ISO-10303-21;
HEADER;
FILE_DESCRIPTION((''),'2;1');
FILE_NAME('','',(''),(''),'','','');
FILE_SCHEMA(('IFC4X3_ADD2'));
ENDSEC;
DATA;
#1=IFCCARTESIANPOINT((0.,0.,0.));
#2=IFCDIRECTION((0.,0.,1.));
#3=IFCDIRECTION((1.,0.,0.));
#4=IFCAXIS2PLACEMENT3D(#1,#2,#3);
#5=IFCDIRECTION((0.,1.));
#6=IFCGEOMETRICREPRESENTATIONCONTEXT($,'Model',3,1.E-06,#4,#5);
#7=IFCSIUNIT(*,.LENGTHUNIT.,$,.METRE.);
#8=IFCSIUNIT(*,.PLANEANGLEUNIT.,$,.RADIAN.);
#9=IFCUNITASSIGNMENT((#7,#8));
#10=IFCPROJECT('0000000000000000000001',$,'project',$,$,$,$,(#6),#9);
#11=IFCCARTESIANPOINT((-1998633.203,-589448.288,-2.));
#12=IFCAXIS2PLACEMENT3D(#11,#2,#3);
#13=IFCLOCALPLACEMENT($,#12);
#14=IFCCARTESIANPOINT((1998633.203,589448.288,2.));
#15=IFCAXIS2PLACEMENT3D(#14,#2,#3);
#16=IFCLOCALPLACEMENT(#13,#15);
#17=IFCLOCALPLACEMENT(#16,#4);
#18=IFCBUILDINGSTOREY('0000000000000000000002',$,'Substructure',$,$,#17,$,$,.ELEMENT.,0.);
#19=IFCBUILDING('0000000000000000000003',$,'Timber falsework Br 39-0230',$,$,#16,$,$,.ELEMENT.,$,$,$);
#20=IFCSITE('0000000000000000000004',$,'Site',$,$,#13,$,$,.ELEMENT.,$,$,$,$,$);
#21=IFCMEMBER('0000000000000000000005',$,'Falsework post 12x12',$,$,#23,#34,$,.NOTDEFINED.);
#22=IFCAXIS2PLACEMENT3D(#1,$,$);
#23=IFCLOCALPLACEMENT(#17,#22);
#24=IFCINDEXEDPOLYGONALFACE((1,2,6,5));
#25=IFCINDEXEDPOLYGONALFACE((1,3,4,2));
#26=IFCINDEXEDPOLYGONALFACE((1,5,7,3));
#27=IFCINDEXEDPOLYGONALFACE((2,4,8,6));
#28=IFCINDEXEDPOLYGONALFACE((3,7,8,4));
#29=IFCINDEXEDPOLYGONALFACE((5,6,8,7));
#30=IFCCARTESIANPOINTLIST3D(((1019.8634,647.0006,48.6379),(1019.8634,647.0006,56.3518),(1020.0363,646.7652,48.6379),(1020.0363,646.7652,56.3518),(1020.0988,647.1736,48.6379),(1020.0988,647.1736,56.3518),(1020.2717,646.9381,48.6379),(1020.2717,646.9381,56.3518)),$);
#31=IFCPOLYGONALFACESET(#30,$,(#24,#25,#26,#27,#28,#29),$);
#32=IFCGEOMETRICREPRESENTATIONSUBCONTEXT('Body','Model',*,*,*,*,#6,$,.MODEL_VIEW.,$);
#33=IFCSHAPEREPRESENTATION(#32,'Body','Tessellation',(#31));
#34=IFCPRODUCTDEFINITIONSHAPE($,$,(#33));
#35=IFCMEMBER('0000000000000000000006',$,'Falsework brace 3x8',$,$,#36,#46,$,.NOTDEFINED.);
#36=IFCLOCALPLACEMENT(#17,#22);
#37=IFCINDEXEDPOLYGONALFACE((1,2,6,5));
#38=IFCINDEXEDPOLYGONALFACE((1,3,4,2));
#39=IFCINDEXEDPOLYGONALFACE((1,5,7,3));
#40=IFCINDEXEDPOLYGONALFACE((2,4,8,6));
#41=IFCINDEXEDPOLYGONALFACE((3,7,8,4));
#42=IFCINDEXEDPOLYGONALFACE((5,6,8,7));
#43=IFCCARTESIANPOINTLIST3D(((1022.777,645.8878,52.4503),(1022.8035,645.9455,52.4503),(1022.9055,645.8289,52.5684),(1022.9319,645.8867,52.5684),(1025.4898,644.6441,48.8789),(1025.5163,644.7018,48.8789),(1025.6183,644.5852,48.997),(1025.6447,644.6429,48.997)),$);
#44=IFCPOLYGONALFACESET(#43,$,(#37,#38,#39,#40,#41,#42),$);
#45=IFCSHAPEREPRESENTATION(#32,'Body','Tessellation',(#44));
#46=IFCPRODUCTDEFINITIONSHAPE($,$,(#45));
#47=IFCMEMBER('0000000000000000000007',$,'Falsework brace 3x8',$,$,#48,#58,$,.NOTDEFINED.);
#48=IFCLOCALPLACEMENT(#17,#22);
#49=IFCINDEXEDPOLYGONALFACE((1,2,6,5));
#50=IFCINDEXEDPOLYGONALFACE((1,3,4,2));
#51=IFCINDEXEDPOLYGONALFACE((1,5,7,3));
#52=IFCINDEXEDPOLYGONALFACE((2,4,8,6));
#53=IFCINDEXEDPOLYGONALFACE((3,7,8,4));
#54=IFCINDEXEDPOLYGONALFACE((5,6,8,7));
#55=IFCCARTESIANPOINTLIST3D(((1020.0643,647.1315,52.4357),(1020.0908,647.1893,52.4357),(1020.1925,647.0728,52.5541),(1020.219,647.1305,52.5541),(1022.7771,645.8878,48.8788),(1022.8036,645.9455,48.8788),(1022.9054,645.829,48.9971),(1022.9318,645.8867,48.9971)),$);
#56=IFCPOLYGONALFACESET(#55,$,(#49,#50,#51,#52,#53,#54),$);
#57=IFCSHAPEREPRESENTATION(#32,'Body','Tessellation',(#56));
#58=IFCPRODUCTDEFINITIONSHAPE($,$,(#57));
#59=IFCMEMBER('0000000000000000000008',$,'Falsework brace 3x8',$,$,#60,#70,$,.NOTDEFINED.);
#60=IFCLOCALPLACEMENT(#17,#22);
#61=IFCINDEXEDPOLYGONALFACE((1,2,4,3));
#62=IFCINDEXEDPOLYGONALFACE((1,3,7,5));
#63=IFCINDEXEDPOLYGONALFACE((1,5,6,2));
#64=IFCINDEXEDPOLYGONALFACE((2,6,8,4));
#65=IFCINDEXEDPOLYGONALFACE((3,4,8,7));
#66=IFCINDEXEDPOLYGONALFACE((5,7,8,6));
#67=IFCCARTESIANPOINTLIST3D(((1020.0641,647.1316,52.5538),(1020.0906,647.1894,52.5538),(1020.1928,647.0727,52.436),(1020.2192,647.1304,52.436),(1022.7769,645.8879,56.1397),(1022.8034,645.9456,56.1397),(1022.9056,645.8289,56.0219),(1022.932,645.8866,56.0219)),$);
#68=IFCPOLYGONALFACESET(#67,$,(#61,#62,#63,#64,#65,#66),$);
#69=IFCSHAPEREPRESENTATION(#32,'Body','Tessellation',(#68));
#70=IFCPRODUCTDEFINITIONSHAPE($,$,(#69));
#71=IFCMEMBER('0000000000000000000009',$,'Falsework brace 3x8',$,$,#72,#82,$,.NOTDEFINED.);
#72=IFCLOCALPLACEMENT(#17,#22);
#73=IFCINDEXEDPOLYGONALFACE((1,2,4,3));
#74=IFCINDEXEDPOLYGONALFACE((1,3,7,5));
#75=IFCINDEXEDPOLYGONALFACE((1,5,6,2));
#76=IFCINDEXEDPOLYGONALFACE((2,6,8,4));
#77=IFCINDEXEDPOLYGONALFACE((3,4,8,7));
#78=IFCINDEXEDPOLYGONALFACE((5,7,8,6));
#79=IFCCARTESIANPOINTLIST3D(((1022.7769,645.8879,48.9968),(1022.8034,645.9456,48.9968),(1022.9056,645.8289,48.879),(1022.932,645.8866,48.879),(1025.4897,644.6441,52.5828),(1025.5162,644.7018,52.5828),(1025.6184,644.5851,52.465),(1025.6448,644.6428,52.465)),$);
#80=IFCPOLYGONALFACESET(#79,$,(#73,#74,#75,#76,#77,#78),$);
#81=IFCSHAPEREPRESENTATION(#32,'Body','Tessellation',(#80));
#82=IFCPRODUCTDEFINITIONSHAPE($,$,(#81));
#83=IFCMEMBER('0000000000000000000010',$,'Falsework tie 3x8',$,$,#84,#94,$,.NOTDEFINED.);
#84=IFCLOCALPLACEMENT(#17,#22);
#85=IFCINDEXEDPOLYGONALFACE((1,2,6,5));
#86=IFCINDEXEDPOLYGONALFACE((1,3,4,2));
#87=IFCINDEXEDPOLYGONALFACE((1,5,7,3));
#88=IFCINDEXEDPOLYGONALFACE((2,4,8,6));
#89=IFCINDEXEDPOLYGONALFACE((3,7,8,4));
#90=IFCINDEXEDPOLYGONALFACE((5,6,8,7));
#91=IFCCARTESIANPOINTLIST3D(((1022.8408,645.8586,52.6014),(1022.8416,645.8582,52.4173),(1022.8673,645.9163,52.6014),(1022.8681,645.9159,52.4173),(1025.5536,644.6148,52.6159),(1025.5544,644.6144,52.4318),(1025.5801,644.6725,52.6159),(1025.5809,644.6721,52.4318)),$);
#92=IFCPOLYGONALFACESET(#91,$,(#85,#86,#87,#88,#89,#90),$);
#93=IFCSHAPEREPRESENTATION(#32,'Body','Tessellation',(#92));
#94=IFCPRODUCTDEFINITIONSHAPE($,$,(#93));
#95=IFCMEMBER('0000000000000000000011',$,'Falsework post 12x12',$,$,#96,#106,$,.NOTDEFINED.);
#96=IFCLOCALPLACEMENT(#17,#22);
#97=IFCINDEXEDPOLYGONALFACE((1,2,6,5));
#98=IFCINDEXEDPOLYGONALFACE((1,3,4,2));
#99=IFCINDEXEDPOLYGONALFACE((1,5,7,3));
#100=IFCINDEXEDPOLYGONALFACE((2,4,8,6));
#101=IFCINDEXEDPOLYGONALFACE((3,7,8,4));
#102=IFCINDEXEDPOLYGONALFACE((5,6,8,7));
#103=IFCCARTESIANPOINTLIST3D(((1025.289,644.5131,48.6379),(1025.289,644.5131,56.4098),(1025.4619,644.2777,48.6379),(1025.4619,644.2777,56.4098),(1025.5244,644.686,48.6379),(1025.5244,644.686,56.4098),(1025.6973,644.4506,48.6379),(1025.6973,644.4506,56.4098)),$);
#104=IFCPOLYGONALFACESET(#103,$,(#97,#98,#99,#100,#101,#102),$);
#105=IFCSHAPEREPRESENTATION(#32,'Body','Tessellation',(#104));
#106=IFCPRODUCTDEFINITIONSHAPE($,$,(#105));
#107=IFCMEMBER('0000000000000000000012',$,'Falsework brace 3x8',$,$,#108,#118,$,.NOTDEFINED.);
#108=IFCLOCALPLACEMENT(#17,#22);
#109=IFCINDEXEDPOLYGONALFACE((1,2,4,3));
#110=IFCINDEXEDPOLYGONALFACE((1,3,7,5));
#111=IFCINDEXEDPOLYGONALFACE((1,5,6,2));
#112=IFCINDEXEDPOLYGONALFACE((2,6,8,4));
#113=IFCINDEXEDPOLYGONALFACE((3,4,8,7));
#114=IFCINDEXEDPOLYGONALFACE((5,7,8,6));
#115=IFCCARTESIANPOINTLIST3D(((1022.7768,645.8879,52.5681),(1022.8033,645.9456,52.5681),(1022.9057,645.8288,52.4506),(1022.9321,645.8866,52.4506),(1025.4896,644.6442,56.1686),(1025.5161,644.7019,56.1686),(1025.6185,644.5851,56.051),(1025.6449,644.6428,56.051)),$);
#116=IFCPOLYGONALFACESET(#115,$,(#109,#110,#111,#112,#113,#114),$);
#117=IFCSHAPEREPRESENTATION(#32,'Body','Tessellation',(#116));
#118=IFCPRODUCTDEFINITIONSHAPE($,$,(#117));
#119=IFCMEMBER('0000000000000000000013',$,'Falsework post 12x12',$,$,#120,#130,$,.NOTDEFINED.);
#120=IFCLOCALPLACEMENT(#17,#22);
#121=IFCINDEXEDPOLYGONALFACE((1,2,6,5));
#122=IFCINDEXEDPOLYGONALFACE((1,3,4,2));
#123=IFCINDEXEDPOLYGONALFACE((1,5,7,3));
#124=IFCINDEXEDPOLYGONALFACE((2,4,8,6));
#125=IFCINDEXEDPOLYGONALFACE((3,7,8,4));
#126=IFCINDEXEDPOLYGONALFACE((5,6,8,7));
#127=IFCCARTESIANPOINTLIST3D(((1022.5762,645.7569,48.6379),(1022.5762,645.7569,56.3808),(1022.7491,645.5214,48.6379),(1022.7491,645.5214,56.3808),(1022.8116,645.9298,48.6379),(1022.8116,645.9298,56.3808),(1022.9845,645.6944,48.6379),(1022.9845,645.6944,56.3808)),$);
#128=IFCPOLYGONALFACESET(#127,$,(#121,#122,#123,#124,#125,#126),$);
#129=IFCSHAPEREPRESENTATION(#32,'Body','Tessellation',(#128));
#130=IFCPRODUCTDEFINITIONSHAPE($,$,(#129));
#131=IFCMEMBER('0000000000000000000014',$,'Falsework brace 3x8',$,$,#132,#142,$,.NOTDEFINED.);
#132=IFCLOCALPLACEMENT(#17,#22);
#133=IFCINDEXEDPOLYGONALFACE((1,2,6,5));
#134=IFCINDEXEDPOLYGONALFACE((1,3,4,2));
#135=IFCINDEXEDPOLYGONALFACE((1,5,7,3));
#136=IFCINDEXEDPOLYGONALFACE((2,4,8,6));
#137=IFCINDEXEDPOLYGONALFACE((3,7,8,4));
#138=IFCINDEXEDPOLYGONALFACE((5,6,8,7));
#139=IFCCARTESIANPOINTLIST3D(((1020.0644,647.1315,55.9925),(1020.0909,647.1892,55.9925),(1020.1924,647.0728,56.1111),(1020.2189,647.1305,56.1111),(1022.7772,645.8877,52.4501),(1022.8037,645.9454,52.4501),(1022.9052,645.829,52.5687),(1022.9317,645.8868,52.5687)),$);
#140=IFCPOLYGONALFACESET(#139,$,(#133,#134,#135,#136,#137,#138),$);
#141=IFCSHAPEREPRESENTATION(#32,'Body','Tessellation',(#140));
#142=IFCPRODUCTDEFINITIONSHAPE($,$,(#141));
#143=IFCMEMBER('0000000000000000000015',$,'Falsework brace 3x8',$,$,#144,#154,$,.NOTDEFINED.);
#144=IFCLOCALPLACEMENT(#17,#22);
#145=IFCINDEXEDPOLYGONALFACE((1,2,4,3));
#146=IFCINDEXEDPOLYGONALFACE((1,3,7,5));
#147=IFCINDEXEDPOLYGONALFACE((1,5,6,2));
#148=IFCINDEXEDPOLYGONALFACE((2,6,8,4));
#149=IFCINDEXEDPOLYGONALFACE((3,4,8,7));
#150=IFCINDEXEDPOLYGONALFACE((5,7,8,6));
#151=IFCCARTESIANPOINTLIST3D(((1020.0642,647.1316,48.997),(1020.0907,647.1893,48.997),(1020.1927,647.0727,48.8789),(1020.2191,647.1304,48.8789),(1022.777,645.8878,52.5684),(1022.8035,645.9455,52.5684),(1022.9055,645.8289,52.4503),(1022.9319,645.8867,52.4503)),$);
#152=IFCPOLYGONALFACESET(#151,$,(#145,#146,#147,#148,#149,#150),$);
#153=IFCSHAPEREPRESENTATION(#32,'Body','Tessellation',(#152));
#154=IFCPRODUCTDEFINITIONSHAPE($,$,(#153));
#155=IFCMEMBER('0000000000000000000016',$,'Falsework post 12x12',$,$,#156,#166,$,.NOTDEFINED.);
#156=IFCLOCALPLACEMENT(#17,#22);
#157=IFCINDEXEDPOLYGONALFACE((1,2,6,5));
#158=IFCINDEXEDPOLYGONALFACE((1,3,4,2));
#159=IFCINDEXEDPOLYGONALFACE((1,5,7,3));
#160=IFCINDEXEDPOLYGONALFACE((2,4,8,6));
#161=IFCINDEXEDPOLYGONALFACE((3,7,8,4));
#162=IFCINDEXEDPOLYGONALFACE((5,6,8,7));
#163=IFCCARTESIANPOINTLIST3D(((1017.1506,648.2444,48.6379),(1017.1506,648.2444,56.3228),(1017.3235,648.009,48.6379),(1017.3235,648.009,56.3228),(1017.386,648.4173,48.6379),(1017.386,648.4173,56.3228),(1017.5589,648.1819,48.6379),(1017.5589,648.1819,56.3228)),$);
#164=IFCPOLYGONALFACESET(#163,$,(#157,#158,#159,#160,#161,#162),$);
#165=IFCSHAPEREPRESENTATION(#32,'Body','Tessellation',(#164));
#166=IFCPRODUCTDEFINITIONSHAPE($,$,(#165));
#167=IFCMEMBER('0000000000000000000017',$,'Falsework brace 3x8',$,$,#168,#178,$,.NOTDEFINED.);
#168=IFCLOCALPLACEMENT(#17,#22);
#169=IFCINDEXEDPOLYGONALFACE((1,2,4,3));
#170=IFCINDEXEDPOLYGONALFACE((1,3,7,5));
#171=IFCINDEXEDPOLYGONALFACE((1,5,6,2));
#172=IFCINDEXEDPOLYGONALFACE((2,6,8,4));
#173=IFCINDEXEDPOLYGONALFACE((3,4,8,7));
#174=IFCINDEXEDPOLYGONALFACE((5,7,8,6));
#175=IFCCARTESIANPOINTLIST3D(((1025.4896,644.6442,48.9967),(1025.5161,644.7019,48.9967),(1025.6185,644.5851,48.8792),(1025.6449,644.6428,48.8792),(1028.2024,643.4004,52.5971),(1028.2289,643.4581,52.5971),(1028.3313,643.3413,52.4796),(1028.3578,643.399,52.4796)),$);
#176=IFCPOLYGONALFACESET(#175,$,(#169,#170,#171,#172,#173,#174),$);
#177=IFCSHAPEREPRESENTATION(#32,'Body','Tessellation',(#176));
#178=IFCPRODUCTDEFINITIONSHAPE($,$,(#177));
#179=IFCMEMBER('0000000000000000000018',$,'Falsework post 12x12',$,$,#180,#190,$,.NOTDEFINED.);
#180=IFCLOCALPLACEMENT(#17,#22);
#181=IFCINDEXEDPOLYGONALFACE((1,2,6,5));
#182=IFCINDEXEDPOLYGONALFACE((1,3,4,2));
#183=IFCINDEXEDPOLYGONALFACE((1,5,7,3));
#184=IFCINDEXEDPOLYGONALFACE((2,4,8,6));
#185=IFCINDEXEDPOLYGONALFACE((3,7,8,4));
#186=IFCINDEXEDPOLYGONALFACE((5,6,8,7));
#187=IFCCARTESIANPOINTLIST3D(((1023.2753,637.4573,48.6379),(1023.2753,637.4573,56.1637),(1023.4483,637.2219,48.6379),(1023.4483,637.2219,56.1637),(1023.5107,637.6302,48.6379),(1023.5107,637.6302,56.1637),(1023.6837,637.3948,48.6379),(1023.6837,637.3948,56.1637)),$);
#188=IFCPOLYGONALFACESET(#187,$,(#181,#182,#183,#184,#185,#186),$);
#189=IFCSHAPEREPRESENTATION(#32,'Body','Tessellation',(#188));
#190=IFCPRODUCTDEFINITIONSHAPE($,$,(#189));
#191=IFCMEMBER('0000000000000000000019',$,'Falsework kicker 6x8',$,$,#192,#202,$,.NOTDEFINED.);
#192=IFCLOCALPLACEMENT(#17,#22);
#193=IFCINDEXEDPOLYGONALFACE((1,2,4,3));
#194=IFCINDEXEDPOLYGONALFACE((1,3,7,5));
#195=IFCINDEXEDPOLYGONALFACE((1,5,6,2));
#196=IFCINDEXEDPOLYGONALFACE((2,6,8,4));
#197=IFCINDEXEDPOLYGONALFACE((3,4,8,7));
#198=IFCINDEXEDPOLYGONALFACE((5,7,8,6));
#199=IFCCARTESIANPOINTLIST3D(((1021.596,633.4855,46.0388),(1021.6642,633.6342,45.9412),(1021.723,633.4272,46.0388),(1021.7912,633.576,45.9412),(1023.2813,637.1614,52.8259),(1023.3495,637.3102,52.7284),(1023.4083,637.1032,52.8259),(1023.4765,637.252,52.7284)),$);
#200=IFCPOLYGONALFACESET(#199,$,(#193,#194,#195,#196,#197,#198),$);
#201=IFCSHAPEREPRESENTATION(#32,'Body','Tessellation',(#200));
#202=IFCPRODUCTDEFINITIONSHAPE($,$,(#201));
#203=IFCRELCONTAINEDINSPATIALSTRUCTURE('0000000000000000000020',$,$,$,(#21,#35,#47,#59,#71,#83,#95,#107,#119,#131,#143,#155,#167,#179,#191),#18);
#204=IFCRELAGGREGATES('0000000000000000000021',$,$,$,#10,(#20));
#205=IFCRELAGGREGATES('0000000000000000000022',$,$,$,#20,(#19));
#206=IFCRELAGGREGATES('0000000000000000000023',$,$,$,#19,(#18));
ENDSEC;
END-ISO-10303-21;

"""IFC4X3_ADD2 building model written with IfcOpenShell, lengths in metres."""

from ifc_helpers import new_model, si_unit, direction, frame, origin, origin_with_axes, origin_2d, place, context, subcontext, project, spatial, rectangle, extrude, element, save


model = new_model("IFC4X3_ADD2")

# Units and contexts
model_context = context("Model", 3, precision=1e-06, world=origin_with_axes(), true_north=direction((0.0, 1.0)))
body_context = subcontext(model_context, "Body", "Model", "MODEL_VIEW")
ifc_project = project(units=[si_unit("LENGTHUNIT", "METRE"), si_unit("PLANEANGLEUNIT", "RADIAN")], contexts=[model_context])

# Site, building, storey
site_placement = place(None, frame((-1998633.203, -589448.288, -2.0), z_axis=(0.0, 0.0, 1.0), x_axis=(1.0, 0.0, 0.0)))
site = spatial("IfcSite", under=ifc_project, at=site_placement, Name="Site", CompositionType="ELEMENT")
building_placement = place(site_placement, frame((1998633.203, 589448.288, 2.0), z_axis=(0.0, 0.0, 1.0), x_axis=(1.0, 0.0, 0.0)))
building = spatial("IfcBuilding", under=site, at=building_placement, Name="Timber falsework Br 39-0230", CompositionType="ELEMENT")
storey_placement = place(building_placement, origin_with_axes())
storey = spatial("IfcBuildingStorey", under=building, at=storey_placement, Name="Substructure", CompositionType="ELEMENT", Elevation=0.0)

# Members
member_1_placement = place(storey_placement, frame((1020.0676, 646.9694, 48.6379), z_axis=(0.0, 0.0, 1.0), x_axis=(-0.805928, -0.592013, 0.0)))
element("IfcMember", 1, at=member_1_placement, inside=storey, Name="Falsework post 12x12", PredefinedType="NOTDEFINED", context=body_context, shape_type="SweptSolid", body=[
    extrude(rectangle(XDim=0.2921, YDim=0.2921, at=origin_2d()), origin(), (0.0, 0.0, 1.0), 7.7139),
])
member_2_placement = place(storey_placement, frame((1022.8545, 645.8872, 52.5094), z_axis=(0.582875, -0.267237, -0.76736), x_axis=(0.416765, 0.909014, 0.0)))
element("IfcMember", 2, at=member_2_placement, inside=storey, Name="Falsework brace 3x8", PredefinedType="NOTDEFINED", context=body_context, shape_type="SweptSolid", body=[
    extrude(rectangle(XDim=0.0635, YDim=0.1841, at=origin_2d()), origin(), (0.0, 0.0, 1.0), 4.6542),
])
member_3_placement = place(storey_placement, frame((1020.1417, 647.131, 52.4949), z_axis=(0.584271, -0.267877, -0.766074), x_axis=(0.416765, 0.909014, 0.0)))
element("IfcMember", 3, at=member_3_placement, inside=storey, Name="Falsework brace 3x8", PredefinedType="NOTDEFINED", context=body_context, shape_type="SweptSolid", body=[
    extrude(rectangle(XDim=0.0635, YDim=0.1841, at=origin_2d()), origin(), (0.0, 0.0, 1.0), 4.6431),
])
member_4_placement = place(storey_placement, frame((1020.1417, 647.131, 52.4949), z_axis=(0.581484, -0.266599, 0.768636), x_axis=(0.416765, 0.909014, 0.0)))
element("IfcMember", 4, at=member_4_placement, inside=storey, Name="Falsework brace 3x8", PredefinedType="NOTDEFINED", context=body_context, shape_type="SweptSolid", body=[
    extrude(rectangle(XDim=0.0635, YDim=0.1841, at=origin_2d()), origin(), (0.0, 0.0, 1.0), 4.6653),
])
member_5_placement = place(storey_placement, frame((1022.8545, 645.8872, 48.9379), z_axis=(0.581484, -0.266599, 0.768636), x_axis=(0.416765, 0.909014, 0.0)))
element("IfcMember", 5, at=member_5_placement, inside=storey, Name="Falsework brace 3x8", PredefinedType="NOTDEFINED", context=body_context, shape_type="SweptSolid", body=[
    extrude(rectangle(XDim=0.0635, YDim=0.1841, at=origin_2d()), origin(), (0.0, 0.0, 1.0), 4.6653),
])
member_6_placement = place(storey_placement, frame((1022.8545, 645.8872, 52.5094), z_axis=(0.909003, -0.41676, 0.004859), x_axis=(0.416765, 0.909014, 0.0)))
element("IfcMember", 6, at=member_6_placement, inside=storey, Name="Falsework tie 3x8", PredefinedType="NOTDEFINED", context=body_context, shape_type="SweptSolid", body=[
    extrude(rectangle(XDim=0.0635, YDim=0.1841, at=origin_2d()), origin(), (0.0, 0.0, 1.0), 2.9844),
])
member_7_placement = place(storey_placement, frame((1025.4932, 644.4818, 48.6379), z_axis=(0.0, 0.0, 1.0), x_axis=(-0.805928, -0.592013, 0.0)))
element("IfcMember", 7, at=member_7_placement, inside=storey, Name="Falsework post 12x12", PredefinedType="NOTDEFINED", context=body_context, shape_type="SweptSolid", body=[
    extrude(rectangle(XDim=0.2921, YDim=0.2921, at=origin_2d()), origin(), (0.0, 0.0, 1.0), 7.7719),
])
member_8_placement = place(storey_placement, frame((1022.8545, 645.8872, 52.5094), z_axis=(0.580097, -0.265963, 0.769904), x_axis=(0.416765, 0.909014, 0.0)))
element("IfcMember", 8, at=member_8_placement, inside=storey, Name="Falsework brace 3x8", PredefinedType="NOTDEFINED", context=body_context, shape_type="SweptSolid", body=[
    extrude(rectangle(XDim=0.0635, YDim=0.1841, at=origin_2d()), origin(), (0.0, 0.0, 1.0), 4.6765),
])
member_9_placement = place(storey_placement, frame((1022.7804, 645.7256, 48.6379), z_axis=(0.0, 0.0, 1.0), x_axis=(-0.805928, -0.592013, 0.0)))
element("IfcMember", 9, at=member_9_placement, inside=storey, Name="Falsework post 12x12", PredefinedType="NOTDEFINED", context=body_context, shape_type="SweptSolid", body=[
    extrude(rectangle(XDim=0.2921, YDim=0.2921, at=origin_2d()), origin(), (0.0, 0.0, 1.0), 7.7429),
])
member_10_placement = place(storey_placement, frame((1020.1417, 647.131, 56.0518), z_axis=(0.585671, -0.268519, -0.764779), x_axis=(0.416765, 0.909014, 0.0)))
element("IfcMember", 10, at=member_10_placement, inside=storey, Name="Falsework brace 3x8", PredefinedType="NOTDEFINED", context=body_context, shape_type="SweptSolid", body=[
    extrude(rectangle(XDim=0.0635, YDim=0.1841, at=origin_2d()), origin(), (0.0, 0.0, 1.0), 4.632),
])
member_11_placement = place(storey_placement, frame((1020.1417, 647.131, 48.9379), z_axis=(0.582875, -0.267237, 0.76736), x_axis=(0.416765, 0.909014, 0.0)))
element("IfcMember", 11, at=member_11_placement, inside=storey, Name="Falsework brace 3x8", PredefinedType="NOTDEFINED", context=body_context, shape_type="SweptSolid", body=[
    extrude(rectangle(XDim=0.0635, YDim=0.1841, at=origin_2d()), origin(), (0.0, 0.0, 1.0), 4.6542),
])
member_12_placement = place(storey_placement, frame((1017.3548, 648.2132, 48.6379), z_axis=(0.0, 0.0, 1.0), x_axis=(-0.805928, -0.592013, 0.0)))
element("IfcMember", 12, at=member_12_placement, inside=storey, Name="Falsework post 12x12", PredefinedType="NOTDEFINED", context=body_context, shape_type="SweptSolid", body=[
    extrude(rectangle(XDim=0.2921, YDim=0.2921, at=origin_2d()), origin(), (0.0, 0.0, 1.0), 7.6849),
])
member_13_placement = place(storey_placement, frame((1025.5673, 644.6435, 48.9379), z_axis=(0.580097, -0.265963, 0.769904), x_axis=(0.416765, 0.909014, 0.0)))
element("IfcMember", 13, at=member_13_placement, inside=storey, Name="Falsework brace 3x8", PredefinedType="NOTDEFINED", context=body_context, shape_type="SweptSolid", body=[
    extrude(rectangle(XDim=0.0635, YDim=0.1841, at=origin_2d()), origin(), (0.0, 0.0, 1.0), 4.6765),
])
member_14_placement = place(storey_placement, frame((1023.4795, 637.4261, 48.6379), z_axis=(0.0, 0.0, 1.0), x_axis=(-0.805928, -0.592013, 0.0)))
element("IfcMember", 14, at=member_14_placement, inside=storey, Name="Falsework post 12x12", PredefinedType="NOTDEFINED", context=body_context, shape_type="SweptSolid", body=[
    extrude(rectangle(XDim=0.2921, YDim=0.2921, at=origin_2d()), origin(), (0.0, 0.0, 1.0), 7.5258),
])
member_15_placement = place(storey_placement, frame((1023.3789, 637.2067, 52.7771), z_axis=(-0.213324, -0.465284, -0.859072), x_axis=(0.909014, -0.416765, 0.0)))
element("IfcMember", 15, at=member_15_placement, inside=storey, Name="Falsework kicker 6x8", PredefinedType="NOTDEFINED", context=body_context, shape_type="SweptSolid", body=[
    extrude(rectangle(XDim=0.1397, YDim=0.1905, at=origin_2d()), origin(), (0.0, 0.0, 1.0), 7.9005),
])

save(model, "model.ifc")
